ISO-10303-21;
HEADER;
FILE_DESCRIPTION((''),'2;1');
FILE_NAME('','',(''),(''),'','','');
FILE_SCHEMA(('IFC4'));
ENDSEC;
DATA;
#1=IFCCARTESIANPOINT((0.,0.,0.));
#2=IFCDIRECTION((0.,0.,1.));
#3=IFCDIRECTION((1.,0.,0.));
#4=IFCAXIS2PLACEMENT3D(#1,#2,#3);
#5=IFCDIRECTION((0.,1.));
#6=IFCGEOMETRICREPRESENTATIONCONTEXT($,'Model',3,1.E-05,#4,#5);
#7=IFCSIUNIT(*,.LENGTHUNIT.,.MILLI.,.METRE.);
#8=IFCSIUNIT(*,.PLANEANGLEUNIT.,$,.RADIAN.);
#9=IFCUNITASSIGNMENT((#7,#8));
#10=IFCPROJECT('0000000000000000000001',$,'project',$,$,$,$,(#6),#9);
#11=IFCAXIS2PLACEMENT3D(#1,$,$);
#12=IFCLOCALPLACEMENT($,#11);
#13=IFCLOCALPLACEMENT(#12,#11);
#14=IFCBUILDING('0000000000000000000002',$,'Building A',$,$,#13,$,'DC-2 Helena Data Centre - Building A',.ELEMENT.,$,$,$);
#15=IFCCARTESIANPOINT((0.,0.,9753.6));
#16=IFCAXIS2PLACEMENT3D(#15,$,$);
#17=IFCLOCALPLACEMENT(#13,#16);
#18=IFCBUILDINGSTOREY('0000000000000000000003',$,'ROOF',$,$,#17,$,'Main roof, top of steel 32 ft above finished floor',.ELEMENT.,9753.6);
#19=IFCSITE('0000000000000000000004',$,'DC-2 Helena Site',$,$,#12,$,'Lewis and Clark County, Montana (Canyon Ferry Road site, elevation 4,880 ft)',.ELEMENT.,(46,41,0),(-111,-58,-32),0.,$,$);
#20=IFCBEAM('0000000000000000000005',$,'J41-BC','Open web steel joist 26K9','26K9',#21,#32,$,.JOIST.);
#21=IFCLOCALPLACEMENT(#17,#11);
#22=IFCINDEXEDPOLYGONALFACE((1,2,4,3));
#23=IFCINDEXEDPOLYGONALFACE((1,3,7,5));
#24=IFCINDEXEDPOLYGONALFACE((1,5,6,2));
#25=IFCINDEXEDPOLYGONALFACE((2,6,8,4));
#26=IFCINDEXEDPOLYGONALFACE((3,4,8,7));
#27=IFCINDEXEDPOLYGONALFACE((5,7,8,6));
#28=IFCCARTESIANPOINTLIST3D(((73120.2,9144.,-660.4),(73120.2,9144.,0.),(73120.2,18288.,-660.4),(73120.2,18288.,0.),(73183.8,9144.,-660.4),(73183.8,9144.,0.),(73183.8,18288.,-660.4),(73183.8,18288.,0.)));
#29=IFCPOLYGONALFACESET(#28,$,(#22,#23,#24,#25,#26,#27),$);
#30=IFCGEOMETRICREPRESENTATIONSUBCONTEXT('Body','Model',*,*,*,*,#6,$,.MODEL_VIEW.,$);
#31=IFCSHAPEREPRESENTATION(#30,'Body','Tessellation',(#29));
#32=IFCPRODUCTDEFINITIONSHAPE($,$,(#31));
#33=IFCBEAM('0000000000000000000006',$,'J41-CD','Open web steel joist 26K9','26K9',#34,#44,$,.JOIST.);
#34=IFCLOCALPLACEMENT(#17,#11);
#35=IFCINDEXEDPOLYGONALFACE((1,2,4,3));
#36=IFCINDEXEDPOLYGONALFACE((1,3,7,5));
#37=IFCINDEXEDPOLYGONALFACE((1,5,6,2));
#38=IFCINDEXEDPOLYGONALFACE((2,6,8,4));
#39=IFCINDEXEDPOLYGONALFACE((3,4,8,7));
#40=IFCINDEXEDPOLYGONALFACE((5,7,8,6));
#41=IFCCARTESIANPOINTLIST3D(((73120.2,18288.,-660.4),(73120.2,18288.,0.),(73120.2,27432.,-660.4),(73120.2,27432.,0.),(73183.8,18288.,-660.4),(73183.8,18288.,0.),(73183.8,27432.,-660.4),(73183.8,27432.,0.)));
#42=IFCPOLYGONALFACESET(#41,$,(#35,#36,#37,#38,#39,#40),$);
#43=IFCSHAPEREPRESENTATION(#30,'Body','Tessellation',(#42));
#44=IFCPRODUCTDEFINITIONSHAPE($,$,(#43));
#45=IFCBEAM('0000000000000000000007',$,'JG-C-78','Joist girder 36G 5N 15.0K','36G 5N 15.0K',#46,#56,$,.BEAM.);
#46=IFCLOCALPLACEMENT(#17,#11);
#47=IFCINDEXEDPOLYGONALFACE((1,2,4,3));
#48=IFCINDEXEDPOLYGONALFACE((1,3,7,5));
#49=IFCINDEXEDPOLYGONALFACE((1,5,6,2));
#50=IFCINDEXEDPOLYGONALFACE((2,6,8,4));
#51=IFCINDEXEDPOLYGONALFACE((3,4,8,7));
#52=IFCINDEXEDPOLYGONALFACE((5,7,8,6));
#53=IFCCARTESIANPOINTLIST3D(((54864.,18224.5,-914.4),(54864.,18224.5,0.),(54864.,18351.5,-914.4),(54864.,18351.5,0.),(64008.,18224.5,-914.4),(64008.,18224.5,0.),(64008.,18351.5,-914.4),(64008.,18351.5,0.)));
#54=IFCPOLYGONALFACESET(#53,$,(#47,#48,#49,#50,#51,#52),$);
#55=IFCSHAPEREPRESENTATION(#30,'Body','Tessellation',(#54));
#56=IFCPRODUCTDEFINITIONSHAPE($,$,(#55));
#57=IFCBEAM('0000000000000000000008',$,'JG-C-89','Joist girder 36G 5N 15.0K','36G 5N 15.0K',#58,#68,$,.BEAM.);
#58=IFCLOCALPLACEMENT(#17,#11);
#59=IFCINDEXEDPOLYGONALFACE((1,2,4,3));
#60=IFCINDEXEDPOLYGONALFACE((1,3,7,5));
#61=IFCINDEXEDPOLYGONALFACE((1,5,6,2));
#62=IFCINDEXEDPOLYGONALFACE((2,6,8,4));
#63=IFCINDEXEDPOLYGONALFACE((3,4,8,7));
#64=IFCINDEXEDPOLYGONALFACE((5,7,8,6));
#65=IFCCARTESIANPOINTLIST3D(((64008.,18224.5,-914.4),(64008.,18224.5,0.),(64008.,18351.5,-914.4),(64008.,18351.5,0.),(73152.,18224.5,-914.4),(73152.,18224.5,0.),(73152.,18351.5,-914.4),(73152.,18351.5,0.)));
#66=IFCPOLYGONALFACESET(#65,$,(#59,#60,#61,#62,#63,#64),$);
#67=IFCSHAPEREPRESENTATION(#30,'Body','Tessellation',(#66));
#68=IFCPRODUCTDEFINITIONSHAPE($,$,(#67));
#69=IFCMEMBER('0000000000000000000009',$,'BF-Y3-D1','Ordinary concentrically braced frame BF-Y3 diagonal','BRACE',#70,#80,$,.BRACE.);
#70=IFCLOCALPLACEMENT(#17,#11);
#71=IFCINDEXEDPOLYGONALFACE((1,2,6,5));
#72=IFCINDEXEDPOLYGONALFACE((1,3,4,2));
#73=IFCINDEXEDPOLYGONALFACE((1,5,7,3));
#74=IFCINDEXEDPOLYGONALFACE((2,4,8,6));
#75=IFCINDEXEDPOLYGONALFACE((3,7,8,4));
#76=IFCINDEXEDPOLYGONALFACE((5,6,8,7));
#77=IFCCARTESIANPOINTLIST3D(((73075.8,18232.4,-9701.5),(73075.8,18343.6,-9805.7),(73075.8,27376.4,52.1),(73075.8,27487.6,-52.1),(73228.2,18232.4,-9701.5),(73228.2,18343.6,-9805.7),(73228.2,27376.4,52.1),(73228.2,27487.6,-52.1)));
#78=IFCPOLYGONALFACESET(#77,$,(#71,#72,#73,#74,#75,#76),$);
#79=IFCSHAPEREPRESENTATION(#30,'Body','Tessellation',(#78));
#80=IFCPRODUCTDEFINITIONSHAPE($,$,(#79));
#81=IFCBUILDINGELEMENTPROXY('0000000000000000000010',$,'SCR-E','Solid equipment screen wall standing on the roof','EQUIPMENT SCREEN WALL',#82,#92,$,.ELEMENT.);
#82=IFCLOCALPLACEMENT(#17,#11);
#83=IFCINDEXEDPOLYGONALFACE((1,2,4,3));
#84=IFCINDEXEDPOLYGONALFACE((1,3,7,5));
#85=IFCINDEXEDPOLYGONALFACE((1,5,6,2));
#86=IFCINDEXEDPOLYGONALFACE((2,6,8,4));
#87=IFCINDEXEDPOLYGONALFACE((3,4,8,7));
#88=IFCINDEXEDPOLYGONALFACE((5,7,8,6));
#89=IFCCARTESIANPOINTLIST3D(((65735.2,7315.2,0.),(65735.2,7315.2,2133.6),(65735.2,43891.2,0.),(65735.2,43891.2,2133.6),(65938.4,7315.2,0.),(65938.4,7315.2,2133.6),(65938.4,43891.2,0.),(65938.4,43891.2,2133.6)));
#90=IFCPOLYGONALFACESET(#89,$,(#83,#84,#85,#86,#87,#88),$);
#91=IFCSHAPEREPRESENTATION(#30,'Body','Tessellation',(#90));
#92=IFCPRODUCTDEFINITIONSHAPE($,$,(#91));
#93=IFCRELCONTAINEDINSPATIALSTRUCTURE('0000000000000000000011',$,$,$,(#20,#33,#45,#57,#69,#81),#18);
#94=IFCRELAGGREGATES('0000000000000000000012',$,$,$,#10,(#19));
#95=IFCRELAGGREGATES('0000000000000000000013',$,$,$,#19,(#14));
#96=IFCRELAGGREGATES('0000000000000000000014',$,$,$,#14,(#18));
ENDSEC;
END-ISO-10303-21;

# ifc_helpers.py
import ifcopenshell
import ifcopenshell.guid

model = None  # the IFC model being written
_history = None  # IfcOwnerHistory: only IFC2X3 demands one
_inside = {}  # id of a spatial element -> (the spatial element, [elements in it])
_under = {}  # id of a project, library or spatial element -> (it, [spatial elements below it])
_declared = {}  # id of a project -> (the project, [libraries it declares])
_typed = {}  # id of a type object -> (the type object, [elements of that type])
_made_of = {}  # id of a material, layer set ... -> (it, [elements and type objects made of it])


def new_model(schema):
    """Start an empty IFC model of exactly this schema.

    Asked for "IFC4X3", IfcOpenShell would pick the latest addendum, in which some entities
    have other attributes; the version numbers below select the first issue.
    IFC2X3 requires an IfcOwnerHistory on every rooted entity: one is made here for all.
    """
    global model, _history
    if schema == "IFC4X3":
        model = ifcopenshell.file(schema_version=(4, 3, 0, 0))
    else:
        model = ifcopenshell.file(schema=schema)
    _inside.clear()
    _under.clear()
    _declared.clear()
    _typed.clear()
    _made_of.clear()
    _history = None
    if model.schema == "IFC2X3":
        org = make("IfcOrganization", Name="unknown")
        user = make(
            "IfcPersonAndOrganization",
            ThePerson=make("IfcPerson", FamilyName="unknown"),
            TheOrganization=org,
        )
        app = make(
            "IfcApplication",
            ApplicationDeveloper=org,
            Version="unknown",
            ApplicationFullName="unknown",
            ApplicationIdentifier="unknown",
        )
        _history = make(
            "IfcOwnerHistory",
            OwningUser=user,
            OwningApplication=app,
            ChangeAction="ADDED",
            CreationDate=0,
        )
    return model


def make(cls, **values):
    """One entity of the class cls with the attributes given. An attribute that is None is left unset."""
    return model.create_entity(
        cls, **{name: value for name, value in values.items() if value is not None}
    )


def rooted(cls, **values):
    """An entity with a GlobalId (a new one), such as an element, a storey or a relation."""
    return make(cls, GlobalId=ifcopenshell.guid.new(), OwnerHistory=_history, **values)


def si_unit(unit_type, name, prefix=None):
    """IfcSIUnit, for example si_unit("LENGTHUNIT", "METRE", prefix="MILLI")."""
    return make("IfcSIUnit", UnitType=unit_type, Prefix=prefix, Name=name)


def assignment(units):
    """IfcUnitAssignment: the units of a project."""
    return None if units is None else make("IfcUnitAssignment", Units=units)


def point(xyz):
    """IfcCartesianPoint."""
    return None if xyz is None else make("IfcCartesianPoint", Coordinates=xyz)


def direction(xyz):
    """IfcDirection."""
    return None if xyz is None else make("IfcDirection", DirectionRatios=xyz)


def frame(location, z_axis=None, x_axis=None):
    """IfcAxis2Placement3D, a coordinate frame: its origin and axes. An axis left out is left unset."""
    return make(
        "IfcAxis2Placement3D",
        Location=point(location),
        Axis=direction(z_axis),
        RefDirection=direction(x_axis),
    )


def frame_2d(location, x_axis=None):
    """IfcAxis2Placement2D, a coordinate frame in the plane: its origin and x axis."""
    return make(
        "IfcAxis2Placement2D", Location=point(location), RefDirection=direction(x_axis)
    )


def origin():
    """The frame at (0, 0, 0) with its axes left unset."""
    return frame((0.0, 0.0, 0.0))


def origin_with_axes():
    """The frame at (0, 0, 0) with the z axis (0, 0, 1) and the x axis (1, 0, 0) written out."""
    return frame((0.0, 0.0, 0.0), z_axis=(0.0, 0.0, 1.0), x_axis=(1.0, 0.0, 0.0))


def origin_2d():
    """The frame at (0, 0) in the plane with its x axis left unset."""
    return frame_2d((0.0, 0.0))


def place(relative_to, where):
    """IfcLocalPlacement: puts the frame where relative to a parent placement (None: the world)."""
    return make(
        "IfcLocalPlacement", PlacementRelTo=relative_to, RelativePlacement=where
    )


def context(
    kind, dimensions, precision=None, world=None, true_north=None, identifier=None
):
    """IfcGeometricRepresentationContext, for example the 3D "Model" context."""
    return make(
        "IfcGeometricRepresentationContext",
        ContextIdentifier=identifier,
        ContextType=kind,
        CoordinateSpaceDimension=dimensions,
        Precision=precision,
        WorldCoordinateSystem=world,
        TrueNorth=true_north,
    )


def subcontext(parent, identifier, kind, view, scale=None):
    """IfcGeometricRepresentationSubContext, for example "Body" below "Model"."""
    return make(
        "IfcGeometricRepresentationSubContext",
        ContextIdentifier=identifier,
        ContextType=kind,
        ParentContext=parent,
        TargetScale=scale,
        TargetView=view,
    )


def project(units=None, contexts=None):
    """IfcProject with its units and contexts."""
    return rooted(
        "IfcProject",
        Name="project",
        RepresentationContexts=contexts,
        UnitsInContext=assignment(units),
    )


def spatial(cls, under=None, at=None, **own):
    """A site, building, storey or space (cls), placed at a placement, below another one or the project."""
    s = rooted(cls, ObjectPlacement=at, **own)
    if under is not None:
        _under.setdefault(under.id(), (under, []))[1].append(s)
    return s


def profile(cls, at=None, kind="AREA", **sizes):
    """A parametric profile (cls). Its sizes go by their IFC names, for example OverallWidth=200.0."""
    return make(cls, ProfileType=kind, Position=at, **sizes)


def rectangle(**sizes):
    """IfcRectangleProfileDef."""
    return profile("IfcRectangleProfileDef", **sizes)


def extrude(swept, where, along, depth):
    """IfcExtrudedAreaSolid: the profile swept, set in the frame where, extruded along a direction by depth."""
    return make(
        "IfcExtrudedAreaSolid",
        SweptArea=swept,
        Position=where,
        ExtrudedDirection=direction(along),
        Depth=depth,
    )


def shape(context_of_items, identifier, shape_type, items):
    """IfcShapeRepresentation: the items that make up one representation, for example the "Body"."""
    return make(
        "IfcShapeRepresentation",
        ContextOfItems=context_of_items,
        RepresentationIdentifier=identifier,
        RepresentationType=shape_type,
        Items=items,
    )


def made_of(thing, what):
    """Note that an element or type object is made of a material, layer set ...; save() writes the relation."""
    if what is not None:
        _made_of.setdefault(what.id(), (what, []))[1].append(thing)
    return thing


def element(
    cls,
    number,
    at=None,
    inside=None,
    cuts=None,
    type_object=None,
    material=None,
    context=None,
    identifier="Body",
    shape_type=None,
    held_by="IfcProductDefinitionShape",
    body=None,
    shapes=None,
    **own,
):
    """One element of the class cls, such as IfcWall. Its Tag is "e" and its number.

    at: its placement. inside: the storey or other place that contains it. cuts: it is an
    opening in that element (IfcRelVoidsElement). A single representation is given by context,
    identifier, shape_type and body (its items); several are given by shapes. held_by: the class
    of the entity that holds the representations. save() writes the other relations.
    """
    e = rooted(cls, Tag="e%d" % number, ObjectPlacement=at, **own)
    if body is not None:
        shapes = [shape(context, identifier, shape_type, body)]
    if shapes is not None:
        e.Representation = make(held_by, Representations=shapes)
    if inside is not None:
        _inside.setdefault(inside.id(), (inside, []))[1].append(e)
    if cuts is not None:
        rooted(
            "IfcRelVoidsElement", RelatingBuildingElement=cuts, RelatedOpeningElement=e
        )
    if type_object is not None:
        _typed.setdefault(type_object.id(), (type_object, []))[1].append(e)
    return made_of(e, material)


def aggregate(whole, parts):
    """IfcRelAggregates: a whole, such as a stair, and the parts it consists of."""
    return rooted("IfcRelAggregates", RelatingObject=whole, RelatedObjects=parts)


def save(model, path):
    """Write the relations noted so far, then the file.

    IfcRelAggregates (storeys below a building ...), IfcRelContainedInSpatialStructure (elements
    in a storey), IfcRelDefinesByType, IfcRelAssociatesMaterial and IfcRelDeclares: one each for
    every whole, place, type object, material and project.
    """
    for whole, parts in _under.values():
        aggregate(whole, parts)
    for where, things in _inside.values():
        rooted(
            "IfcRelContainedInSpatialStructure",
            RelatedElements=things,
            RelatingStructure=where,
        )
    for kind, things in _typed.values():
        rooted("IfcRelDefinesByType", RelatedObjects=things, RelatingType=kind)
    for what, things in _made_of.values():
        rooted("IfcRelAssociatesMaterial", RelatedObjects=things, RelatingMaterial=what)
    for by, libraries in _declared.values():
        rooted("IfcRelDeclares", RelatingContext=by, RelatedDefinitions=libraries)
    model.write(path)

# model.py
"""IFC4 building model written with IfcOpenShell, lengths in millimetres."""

from ifc_helpers import new_model, si_unit, direction, frame, origin, origin_with_axes, origin_2d, place, context, subcontext, project, spatial, rectangle, extrude, element, save


model = new_model("IFC4")

# Units and contexts
model_context = context("Model", 3, precision=1e-05, world=origin_with_axes(), true_north=direction((0.0, 1.0)))
body_context = subcontext(model_context, "Body", "Model", "MODEL_VIEW")
ifc_project = project(units=[si_unit("LENGTHUNIT", "METRE", prefix="MILLI"), si_unit("PLANEANGLEUNIT", "RADIAN")], contexts=[model_context])

# Site, building, storey
site_placement = place(None, origin())
site = spatial("IfcSite", under=ifc_project, at=site_placement, Name="DC-2 Helena Site", LongName="Lewis and Clark County, Montana (Canyon Ferry Road site, elevation 4,880 ft)", CompositionType="ELEMENT", RefLatitude=(46, 41, 0), RefLongitude=(-111, -58, -32), RefElevation=0.0)
building_placement = place(site_placement, origin())
building = spatial("IfcBuilding", under=site, at=building_placement, Name="Building A", LongName="DC-2 Helena Data Centre - Building A", CompositionType="ELEMENT")
storey_placement = place(building_placement, frame((0.0, 0.0, 9753.6)))
storey = spatial("IfcBuildingStorey", under=building, at=storey_placement, Name="ROOF", LongName="Main roof, top of steel 32 ft above finished floor", CompositionType="ELEMENT", Elevation=9753.6)

# Shared definitions
placement_1 = place(storey_placement, frame((73152.0, 18288.0, -9753.6)))

# Beams
placement_2 = place(storey_placement, frame((54864.0, 18288.0, 0.0)))
placement_3 = place(storey_placement, frame((64008.0, 18288.0, 0.0)))
for number, where, name in (
    (1, (73152.0, 9144.0, 0.0), "J41-BC"),
    (2, (73152.0, 18288.0, 0.0), "J41-CD"),
):
    element("IfcBeam", number, at=place(storey_placement, frame(where)), inside=storey, Name=name, Description="Open web steel joist 26K9", ObjectType="26K9", PredefinedType="JOIST", context=body_context, shape_type="SweptSolid", body=[
        extrude(rectangle(XDim=63.5, YDim=660.4, at=origin_2d()), frame((0.0, 0.0, -330.2), z_axis=(0.0, 1.0, 0.0), x_axis=(1.0, 0.0, 0.0)), (0.0, 0.0, 1.0), 9144.0),
    ])
element("IfcBeam", 3, at=placement_2, inside=storey, Name="JG-C-78", Description="Joist girder 36G 5N 15.0K", ObjectType="36G 5N 15.0K", PredefinedType="BEAM", context=body_context, shape_type="SweptSolid", body=[
    extrude(rectangle(XDim=127.0, YDim=914.4, at=origin_2d()), frame((0.0, 0.0, -457.2), z_axis=(1.0, 0.0, 0.0), x_axis=(0.0, 1.0, 0.0)), (0.0, 0.0, 1.0), 9144.0),
])
element("IfcBeam", 4, at=placement_3, inside=storey, Name="JG-C-89", Description="Joist girder 36G 5N 15.0K", ObjectType="36G 5N 15.0K", PredefinedType="BEAM", context=body_context, shape_type="SweptSolid", body=[
    extrude(rectangle(XDim=127.0, YDim=914.4, at=origin_2d()), frame((0.0, 0.0, -457.2), z_axis=(1.0, 0.0, 0.0), x_axis=(0.0, 1.0, 0.0)), (0.0, 0.0, 1.0), 9144.0),
])

# Member
element("IfcMember", 5, at=placement_1, inside=storey, Name="BF-Y3-D1", Description="Ordinary concentrically braced frame BF-Y3 diagonal", ObjectType="BRACE", PredefinedType="BRACE", context=body_context, shape_type="SweptSolid", body=[
    extrude(rectangle(XDim=152.4, YDim=152.4, at=origin_2d()), frame((0.0, 0.0, 0.0), z_axis=(0.0, 0.683941, 0.729537), x_axis=(1.0, 0.0, 0.0)), (0.0, 0.0, 1.0), 13369.6),
])

# Building element proxy
proxy_placement = place(storey_placement, frame((65836.8, 25603.2, 0.0)))
element("IfcBuildingElementProxy", 6, at=proxy_placement, inside=storey, Name="SCR-E", Description="Solid equipment screen wall standing on the roof", ObjectType="EQUIPMENT SCREEN WALL", PredefinedType="ELEMENT", context=body_context, shape_type="SweptSolid", body=[
    extrude(rectangle(XDim=203.2, YDim=36576.0, at=origin_2d()), origin(), (0.0, 0.0, 1.0), 2133.6),
])

save(model, "model.ifc")
